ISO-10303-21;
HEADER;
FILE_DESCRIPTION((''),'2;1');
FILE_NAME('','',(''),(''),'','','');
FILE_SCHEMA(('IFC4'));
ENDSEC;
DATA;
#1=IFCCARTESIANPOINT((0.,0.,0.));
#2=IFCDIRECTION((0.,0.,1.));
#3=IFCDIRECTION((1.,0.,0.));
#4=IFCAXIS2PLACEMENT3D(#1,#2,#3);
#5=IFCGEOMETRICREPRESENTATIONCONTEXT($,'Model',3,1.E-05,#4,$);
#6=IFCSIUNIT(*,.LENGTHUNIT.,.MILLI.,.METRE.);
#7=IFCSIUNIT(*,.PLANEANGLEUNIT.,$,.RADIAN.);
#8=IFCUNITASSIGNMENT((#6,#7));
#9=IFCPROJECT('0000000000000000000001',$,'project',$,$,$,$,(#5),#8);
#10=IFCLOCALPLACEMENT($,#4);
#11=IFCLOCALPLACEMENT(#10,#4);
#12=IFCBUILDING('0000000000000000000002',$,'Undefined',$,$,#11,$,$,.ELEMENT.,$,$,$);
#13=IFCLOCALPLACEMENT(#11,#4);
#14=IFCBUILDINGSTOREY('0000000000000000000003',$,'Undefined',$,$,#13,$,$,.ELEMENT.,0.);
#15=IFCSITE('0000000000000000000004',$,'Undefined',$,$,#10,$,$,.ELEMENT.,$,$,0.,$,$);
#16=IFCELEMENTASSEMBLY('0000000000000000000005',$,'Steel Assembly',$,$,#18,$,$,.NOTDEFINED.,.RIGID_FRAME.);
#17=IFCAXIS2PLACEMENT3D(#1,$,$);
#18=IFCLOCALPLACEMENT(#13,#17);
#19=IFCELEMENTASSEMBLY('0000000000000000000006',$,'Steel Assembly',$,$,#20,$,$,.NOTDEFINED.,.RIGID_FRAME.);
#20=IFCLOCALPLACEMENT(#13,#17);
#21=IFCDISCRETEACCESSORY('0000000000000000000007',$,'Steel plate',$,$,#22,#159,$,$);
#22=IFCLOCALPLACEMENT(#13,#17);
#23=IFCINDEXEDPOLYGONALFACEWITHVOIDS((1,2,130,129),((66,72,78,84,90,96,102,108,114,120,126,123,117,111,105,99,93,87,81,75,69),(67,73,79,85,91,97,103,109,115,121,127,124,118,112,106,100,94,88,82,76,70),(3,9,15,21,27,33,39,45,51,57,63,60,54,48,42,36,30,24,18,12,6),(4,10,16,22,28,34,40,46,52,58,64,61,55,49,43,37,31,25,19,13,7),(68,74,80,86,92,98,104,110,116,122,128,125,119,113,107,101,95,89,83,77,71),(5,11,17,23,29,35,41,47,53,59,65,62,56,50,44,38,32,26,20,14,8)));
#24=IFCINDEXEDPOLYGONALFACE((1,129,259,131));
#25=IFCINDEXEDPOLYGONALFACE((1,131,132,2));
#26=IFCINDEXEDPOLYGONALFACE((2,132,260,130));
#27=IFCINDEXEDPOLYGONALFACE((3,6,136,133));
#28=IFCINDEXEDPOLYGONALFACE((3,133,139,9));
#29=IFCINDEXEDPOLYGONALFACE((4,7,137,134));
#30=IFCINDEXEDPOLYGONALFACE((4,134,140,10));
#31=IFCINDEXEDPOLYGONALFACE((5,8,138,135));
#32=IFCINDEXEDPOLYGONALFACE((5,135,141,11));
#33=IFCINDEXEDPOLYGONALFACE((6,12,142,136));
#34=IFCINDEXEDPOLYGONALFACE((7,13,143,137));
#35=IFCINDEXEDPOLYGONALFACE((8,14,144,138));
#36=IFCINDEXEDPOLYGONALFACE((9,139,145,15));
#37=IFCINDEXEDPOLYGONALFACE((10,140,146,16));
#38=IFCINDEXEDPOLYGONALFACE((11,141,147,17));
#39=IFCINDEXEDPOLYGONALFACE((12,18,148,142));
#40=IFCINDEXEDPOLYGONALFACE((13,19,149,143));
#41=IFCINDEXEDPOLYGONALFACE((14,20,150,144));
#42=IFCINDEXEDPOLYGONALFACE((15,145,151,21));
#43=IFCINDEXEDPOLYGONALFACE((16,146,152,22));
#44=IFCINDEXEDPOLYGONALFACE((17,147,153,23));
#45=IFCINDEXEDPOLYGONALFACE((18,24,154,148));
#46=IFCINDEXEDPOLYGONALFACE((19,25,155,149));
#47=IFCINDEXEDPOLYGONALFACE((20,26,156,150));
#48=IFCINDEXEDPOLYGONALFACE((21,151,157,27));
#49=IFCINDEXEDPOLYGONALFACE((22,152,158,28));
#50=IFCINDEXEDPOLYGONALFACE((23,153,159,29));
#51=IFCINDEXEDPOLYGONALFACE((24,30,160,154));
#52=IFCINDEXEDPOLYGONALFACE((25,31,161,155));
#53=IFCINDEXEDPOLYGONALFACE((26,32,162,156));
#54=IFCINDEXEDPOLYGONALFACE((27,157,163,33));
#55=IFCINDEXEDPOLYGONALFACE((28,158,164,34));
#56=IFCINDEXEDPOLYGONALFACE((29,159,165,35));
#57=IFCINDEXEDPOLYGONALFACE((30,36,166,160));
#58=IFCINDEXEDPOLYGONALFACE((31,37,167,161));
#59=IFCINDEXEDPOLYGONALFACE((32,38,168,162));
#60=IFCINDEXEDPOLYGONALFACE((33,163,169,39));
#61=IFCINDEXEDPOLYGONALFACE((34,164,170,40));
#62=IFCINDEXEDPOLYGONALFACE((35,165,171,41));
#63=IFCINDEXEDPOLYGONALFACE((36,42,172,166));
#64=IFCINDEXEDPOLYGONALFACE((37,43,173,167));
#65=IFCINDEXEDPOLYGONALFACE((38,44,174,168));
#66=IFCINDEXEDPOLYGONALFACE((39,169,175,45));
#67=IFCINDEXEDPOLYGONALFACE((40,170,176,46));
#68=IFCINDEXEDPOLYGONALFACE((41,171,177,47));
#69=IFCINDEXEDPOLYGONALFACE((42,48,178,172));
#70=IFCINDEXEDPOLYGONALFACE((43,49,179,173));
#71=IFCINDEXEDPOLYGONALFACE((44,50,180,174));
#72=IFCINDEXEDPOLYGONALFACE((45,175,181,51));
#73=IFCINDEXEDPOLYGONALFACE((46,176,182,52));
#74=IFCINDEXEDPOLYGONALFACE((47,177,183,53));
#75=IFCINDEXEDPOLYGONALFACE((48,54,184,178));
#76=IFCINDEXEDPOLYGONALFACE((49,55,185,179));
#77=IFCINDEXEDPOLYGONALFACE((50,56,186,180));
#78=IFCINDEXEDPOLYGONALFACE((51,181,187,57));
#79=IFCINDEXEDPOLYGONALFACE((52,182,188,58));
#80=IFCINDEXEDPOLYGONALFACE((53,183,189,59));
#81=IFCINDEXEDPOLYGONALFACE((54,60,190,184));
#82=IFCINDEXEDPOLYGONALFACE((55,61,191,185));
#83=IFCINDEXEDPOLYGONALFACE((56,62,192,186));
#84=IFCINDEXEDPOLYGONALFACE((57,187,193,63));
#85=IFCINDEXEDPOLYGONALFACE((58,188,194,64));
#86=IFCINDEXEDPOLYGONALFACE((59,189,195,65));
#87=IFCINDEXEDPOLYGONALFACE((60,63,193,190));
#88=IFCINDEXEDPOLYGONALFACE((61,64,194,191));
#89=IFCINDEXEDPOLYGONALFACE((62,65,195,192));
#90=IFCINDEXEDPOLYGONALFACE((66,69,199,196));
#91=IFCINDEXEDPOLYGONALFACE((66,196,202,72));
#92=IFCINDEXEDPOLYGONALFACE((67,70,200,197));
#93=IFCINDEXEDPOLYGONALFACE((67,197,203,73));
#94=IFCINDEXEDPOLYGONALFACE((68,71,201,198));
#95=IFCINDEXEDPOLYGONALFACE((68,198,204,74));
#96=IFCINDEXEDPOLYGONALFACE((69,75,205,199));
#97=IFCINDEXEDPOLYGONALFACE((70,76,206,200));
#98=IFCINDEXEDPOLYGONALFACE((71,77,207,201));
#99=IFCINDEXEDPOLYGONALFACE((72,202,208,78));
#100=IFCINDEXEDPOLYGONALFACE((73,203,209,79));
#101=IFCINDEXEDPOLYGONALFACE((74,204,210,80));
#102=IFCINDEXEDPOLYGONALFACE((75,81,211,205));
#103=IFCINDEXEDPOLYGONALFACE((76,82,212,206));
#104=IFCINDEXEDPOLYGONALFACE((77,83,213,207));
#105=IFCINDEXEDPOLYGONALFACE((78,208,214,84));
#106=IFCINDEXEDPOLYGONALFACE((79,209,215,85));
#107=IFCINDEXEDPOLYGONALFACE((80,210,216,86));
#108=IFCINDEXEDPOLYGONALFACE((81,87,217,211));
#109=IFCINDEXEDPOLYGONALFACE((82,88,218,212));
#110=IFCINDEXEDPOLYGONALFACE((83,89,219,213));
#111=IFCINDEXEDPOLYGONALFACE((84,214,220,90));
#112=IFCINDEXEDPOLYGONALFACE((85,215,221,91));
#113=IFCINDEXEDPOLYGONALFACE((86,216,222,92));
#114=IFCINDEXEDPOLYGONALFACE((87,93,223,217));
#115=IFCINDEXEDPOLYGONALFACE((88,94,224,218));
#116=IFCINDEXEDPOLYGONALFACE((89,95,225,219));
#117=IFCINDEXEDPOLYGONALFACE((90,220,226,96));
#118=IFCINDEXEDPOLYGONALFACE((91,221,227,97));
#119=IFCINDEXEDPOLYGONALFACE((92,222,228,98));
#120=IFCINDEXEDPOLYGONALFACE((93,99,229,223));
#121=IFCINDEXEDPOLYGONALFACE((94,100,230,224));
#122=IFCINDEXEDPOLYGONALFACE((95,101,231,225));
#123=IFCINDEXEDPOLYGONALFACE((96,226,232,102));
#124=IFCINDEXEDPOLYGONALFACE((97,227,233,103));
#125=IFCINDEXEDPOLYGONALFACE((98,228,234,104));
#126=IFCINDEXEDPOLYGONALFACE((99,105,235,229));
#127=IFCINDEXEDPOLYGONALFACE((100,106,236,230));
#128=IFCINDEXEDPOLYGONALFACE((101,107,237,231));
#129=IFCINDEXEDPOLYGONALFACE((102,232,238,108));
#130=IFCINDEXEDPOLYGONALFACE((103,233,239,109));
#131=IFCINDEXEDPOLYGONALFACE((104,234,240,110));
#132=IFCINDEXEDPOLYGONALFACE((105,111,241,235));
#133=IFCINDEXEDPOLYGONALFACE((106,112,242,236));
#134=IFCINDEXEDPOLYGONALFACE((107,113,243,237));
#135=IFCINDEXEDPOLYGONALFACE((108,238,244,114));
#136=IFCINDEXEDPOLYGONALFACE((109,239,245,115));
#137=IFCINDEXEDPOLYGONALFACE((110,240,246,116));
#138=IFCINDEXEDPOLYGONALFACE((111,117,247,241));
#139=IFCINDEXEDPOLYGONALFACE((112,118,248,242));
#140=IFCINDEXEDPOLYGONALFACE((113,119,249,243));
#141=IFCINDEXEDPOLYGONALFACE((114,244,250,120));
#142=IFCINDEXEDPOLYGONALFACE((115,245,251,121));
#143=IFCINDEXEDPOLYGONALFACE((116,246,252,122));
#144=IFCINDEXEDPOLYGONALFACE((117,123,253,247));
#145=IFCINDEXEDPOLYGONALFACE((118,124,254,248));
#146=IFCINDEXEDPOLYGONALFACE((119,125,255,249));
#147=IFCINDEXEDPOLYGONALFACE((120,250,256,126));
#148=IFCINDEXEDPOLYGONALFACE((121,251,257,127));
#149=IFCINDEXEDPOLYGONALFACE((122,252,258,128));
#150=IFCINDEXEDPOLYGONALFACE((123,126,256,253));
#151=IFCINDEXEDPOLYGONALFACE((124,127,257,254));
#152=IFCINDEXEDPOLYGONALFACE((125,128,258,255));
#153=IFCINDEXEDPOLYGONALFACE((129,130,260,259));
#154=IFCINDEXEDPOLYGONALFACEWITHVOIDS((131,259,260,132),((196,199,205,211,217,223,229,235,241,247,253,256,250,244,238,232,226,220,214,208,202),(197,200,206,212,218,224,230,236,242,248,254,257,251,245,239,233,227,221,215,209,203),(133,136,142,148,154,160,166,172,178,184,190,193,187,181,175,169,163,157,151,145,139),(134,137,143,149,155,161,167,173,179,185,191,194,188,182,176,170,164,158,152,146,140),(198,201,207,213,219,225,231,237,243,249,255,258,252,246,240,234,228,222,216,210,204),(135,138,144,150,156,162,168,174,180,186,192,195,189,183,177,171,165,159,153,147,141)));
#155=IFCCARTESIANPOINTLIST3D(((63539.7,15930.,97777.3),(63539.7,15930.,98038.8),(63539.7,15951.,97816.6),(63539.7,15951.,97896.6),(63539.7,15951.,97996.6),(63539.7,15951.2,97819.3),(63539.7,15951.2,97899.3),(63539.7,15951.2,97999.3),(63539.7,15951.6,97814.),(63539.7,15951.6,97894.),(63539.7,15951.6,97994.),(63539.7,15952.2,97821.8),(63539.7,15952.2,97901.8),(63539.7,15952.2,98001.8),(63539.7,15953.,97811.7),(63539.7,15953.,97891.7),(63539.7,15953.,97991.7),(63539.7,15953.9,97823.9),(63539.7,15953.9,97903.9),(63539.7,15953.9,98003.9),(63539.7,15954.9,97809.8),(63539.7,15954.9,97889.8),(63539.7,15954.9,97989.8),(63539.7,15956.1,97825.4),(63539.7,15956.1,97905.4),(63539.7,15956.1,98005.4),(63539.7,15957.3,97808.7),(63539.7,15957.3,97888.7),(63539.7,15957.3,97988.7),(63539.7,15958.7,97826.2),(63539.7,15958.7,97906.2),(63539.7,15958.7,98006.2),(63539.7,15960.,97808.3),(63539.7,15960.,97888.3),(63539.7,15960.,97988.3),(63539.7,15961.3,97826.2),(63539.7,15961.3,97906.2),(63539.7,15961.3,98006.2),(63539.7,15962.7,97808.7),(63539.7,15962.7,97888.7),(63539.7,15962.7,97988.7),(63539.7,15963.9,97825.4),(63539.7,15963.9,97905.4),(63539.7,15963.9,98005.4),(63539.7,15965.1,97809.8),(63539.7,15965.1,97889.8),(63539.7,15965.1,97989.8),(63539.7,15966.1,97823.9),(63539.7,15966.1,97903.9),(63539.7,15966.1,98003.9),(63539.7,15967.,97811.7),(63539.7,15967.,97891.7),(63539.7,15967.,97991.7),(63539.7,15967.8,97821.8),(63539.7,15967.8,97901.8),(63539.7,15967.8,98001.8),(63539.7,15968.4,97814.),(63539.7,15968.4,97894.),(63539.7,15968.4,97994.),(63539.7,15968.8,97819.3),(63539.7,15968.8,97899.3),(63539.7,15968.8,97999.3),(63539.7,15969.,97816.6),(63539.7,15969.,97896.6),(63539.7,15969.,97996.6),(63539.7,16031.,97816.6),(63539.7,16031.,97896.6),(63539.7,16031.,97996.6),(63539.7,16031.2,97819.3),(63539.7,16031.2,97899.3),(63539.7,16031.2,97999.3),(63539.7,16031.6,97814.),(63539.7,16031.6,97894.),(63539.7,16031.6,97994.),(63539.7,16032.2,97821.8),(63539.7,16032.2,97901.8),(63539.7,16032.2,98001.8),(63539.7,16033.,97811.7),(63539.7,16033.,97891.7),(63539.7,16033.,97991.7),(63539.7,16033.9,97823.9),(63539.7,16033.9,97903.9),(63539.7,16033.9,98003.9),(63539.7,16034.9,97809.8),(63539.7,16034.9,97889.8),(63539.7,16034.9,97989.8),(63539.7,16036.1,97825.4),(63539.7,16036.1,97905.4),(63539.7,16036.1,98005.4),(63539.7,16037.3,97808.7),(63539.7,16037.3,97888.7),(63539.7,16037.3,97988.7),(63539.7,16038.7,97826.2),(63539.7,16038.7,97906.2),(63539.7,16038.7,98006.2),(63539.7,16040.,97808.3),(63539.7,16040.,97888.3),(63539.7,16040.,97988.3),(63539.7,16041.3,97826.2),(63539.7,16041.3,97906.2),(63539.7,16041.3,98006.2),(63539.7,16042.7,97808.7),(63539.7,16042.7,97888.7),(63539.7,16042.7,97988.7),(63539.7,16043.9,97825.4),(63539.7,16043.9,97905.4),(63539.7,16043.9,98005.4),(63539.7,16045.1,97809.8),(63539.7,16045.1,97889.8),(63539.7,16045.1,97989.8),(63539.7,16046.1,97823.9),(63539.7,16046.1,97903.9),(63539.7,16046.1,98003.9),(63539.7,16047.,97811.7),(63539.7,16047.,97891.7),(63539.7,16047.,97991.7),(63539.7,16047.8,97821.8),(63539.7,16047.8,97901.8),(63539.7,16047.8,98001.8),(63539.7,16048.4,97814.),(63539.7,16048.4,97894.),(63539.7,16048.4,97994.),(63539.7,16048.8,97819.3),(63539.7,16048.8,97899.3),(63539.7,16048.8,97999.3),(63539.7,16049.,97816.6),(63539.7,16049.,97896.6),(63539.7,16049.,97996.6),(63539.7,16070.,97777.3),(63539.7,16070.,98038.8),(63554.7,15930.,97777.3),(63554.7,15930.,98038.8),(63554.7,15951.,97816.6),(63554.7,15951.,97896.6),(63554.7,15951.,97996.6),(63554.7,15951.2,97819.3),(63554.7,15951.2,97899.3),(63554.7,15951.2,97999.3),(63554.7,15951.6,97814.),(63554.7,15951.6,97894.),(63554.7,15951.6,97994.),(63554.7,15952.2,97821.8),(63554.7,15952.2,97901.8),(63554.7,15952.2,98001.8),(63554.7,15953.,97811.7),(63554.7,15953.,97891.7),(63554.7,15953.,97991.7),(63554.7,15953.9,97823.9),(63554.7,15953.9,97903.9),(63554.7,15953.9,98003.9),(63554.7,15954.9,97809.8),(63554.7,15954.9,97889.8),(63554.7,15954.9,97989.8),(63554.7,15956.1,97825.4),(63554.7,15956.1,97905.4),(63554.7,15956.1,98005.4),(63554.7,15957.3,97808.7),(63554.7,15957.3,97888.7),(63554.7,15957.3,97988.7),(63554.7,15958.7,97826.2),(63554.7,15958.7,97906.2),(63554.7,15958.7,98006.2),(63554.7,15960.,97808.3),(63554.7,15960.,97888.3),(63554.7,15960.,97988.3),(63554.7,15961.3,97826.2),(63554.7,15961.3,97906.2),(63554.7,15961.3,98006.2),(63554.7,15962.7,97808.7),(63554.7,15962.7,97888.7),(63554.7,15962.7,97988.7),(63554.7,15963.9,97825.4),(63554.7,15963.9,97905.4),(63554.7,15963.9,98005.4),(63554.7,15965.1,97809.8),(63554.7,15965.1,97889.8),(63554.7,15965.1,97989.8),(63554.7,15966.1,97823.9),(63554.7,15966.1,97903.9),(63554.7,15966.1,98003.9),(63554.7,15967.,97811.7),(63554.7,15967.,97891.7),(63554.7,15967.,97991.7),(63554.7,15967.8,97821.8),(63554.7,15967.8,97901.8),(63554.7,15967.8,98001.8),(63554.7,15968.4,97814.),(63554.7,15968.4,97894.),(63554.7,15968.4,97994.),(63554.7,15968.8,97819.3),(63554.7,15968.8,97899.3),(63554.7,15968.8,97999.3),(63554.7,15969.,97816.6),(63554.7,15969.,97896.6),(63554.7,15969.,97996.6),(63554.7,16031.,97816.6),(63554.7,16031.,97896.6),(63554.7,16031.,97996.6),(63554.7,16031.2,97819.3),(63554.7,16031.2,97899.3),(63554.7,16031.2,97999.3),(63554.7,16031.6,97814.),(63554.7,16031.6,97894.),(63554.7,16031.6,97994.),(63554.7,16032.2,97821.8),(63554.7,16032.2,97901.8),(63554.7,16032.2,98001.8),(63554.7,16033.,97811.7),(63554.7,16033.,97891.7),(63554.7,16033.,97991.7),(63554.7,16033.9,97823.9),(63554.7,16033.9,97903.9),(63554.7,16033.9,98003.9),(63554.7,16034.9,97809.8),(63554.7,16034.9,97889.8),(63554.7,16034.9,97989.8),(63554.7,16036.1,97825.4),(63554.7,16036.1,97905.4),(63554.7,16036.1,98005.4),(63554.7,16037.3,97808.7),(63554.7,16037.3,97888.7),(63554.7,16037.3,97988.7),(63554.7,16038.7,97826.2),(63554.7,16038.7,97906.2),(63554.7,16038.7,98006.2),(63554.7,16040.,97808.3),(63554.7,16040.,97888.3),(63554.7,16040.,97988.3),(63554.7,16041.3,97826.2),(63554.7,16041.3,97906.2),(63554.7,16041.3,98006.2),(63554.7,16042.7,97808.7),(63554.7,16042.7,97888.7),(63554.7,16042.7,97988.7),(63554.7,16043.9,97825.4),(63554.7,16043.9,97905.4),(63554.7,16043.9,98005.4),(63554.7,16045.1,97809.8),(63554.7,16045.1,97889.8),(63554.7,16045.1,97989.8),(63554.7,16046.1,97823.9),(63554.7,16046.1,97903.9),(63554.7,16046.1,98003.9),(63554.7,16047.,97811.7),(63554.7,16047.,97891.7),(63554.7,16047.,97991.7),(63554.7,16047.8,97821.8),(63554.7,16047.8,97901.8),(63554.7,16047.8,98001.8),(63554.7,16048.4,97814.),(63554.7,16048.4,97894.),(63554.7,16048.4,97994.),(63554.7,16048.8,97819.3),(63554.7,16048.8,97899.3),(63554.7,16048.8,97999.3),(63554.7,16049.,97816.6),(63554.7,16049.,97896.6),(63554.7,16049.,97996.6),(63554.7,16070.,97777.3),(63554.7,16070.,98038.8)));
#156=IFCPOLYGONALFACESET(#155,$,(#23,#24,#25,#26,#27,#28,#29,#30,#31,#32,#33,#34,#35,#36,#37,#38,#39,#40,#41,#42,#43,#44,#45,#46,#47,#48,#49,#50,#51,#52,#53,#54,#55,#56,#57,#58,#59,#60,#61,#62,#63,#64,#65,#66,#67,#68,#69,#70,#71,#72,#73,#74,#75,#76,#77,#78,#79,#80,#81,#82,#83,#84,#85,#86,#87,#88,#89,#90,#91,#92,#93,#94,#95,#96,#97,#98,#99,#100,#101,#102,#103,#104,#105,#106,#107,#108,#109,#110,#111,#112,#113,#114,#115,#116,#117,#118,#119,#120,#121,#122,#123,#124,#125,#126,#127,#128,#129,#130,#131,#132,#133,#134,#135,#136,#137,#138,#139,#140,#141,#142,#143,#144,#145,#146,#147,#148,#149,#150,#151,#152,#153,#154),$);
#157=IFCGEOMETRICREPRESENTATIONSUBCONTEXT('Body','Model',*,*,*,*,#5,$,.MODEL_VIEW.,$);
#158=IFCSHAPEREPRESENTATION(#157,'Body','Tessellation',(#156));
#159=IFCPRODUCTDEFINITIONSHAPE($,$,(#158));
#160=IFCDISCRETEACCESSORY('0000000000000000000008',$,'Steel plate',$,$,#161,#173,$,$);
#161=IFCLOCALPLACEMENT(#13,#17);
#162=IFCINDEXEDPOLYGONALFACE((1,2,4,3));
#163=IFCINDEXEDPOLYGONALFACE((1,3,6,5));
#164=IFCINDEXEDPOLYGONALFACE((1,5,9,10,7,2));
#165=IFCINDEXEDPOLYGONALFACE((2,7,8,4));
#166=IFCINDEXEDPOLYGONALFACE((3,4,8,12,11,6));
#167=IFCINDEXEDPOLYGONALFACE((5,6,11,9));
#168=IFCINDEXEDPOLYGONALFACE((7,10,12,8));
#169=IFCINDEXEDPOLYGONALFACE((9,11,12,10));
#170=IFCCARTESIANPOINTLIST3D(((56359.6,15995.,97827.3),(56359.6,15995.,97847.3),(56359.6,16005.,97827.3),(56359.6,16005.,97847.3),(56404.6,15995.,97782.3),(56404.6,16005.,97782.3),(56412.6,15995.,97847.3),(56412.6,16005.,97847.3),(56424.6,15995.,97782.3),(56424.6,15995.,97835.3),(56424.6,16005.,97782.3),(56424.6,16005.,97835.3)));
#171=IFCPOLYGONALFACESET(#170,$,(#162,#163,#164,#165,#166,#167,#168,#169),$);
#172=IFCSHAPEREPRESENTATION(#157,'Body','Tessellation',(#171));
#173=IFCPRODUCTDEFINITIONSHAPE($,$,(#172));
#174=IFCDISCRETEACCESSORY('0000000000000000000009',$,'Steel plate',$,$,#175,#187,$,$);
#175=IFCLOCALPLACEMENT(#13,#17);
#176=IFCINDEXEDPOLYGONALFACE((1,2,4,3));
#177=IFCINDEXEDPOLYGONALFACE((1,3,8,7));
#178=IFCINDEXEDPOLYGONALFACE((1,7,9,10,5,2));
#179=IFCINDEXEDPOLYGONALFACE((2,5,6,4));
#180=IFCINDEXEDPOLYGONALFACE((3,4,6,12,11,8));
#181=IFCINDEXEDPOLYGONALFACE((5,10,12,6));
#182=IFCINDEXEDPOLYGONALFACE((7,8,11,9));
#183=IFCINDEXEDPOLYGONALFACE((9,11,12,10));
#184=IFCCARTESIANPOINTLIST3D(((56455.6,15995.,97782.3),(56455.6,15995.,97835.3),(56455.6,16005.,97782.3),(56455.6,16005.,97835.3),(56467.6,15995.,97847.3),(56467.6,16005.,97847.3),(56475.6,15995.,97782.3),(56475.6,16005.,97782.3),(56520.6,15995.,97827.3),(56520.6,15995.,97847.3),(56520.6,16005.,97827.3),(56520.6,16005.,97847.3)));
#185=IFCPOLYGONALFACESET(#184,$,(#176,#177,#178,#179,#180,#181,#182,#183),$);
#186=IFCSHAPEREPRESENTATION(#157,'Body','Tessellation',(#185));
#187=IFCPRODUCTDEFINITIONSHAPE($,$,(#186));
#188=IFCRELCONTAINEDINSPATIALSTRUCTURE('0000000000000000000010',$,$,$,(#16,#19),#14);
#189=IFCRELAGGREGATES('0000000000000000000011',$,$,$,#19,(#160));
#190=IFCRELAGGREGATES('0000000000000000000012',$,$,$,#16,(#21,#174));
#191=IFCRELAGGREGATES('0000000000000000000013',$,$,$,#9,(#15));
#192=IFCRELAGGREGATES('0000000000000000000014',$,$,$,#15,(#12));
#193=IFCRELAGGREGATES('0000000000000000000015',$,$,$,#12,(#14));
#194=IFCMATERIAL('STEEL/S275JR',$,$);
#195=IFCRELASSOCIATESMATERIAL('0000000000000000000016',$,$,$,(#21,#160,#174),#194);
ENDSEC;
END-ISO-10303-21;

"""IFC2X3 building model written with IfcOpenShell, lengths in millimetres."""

from ifc_helpers import new_model, si_unit, frame, origin_with_axes, origin_2d_with_axis, place, context, subcontext, project, spatial, polyline, circle, outline, extrude, source, transform, mapped, material, element, aggregate, save


model = new_model("IFC2X3")

# Units and contexts
model_context = context("Model", 3, precision=1e-05, world=origin_with_axes())
body_context = subcontext(model_context, "Body", "Model", "MODEL_VIEW")
ifc_project = project(units=[si_unit("LENGTHUNIT", "METRE", prefix="MILLI"), si_unit("PLANEANGLEUNIT", "RADIAN")], contexts=[model_context])

# Site, building, storey
site_placement = place(None, origin_with_axes())
site = spatial("IfcSite", under=ifc_project, at=site_placement, Name="Undefined", CompositionType="ELEMENT", RefElevation=0.0)
building_placement = place(site_placement, origin_with_axes())
building = spatial("IfcBuilding", under=site, at=building_placement, Name="Undefined", CompositionType="ELEMENT")
storey_placement = place(building_placement, origin_with_axes())
storey = spatial("IfcBuildingStorey", under=building, at=storey_placement, Name="Undefined", CompositionType="ELEMENT", Elevation=0.0)

# Shared definitions
ifc_material_1 = material(Name="STEEL/S275JR")

# Element assembly
assembly_1_placement = place(storey_placement, origin_with_axes())
assembly_1 = element("IfcElementAssembly", 1, at=assembly_1_placement, inside=storey, Name="Steel Assembly", AssemblyPlace="NOTDEFINED", PredefinedType="RIGID_FRAME")

# Element assembly
assembly_2_placement = place(storey_placement, origin_with_axes())
assembly_2 = element("IfcElementAssembly", 2, at=assembly_2_placement, inside=storey, Name="Steel Assembly", AssemblyPlace="NOTDEFINED", PredefinedType="RIGID_FRAME")

# Discrete accessory, opening
discrete_accessory_1_placement = place(assembly_1_placement, frame((63547.2, 15930.0, 98038.8), z_axis=(-1.0, 0.0, 0.0), x_axis=(0.0, 1.0, 0.0)))
discrete_accessory_1 = element("IfcDiscreteAccessory", 3, at=discrete_accessory_1_placement, material=ifc_material_1, Name="Steel plate", context=body_context, shape_type="SweptSolid", body=[
    extrude(outline(polyline([(0.0, 0.0), (140.0, 0.0), (140.0, 261.5), (0.0, 261.5), (0.0, 0.0)])), frame((0.0, 0.0, -7.5), z_axis=(0.0, 0.0, 1.0), x_axis=(1.0, 0.0, 0.0)), (0.0, 0.0, 1.0), 15.0),
])
shared_shape_1 = source(origin_with_axes(), body_context, "Body", "SweptSolid", [
    extrude(circle(Radius=9.0, at=origin_2d_with_axis()), frame((0.0, -20.1, 0.0), z_axis=(0.0, 1.0, 0.0), x_axis=(1.0, 0.0, 0.0)), (0.0, 0.0, 1.0), 35.3),
])
opening_1_placement = place(assembly_1_placement, frame((63559.7, 16000.0, 97997.3), z_axis=(0.0, -1.0, 0.0), x_axis=(0.0, 0.0, -1.0)))
element("IfcOpeningElement", 4, at=opening_1_placement, cuts=discrete_accessory_1, ObjectType="Opening", context=body_context, shape_type="MappedRepresentation", body=[
    mapped(shared_shape_1, transform((0.0, 0.0, -40.0))),
    mapped(shared_shape_1, transform((100.0, 0.0, -40.0))),
    mapped(shared_shape_1, transform((180.0, 0.0, -40.0))),
    mapped(shared_shape_1, transform((0.0, 0.0, 40.0))),
    mapped(shared_shape_1, transform((100.0, 0.0, 40.0))),
    mapped(shared_shape_1, transform((180.0, 0.0, 40.0))),
])

# Discrete accessories
discrete_accessory_2_placement = place(assembly_2_placement, frame((56359.6, 16000.0, 97847.3), z_axis=(0.0, 1.0, 0.0), x_axis=(1.0, 0.0, 0.0)))
discrete_accessory_2 = element("IfcDiscreteAccessory", 5, at=discrete_accessory_2_placement, material=ifc_material_1, Name="Steel plate", context=body_context, shape_type="SweptSolid", body=[
    extrude(outline(polyline([(0.0, 0.0), (53.0, 0.0), (65.0, 12.0), (65.0, 65.0), (45.0, 65.0), (0.0, 20.0), (0.0, 0.0)])), frame((0.0, 0.0, -5.0), z_axis=(0.0, 0.0, 1.0), x_axis=(1.0, 0.0, 0.0)), (0.0, 0.0, 1.0), 10.0),
])
discrete_accessory_3_placement = place(assembly_1_placement, frame((56520.6, 16000.0, 97847.3), z_axis=(0.0, -1.0, 0.0), x_axis=(-1.0, 0.0, 0.0)))
discrete_accessory_3 = element("IfcDiscreteAccessory", 6, at=discrete_accessory_3_placement, material=ifc_material_1, Name="Steel plate", context=body_context, shape_type="SweptSolid", body=[
    extrude(outline(polyline([(0.0, 0.0), (53.0, 0.0), (65.0, 12.0), (65.0, 65.0), (45.0, 65.0), (0.0, 20.0), (0.0, 0.0)])), frame((0.0, 0.0, -5.0), z_axis=(0.0, 0.0, 1.0), x_axis=(1.0, 0.0, 0.0)), (0.0, 0.0, 1.0), 10.0),
])

aggregate(assembly_2, [discrete_accessory_2])
aggregate(assembly_1, [discrete_accessory_1, discrete_accessory_3])

save(model, "model.ifc")
